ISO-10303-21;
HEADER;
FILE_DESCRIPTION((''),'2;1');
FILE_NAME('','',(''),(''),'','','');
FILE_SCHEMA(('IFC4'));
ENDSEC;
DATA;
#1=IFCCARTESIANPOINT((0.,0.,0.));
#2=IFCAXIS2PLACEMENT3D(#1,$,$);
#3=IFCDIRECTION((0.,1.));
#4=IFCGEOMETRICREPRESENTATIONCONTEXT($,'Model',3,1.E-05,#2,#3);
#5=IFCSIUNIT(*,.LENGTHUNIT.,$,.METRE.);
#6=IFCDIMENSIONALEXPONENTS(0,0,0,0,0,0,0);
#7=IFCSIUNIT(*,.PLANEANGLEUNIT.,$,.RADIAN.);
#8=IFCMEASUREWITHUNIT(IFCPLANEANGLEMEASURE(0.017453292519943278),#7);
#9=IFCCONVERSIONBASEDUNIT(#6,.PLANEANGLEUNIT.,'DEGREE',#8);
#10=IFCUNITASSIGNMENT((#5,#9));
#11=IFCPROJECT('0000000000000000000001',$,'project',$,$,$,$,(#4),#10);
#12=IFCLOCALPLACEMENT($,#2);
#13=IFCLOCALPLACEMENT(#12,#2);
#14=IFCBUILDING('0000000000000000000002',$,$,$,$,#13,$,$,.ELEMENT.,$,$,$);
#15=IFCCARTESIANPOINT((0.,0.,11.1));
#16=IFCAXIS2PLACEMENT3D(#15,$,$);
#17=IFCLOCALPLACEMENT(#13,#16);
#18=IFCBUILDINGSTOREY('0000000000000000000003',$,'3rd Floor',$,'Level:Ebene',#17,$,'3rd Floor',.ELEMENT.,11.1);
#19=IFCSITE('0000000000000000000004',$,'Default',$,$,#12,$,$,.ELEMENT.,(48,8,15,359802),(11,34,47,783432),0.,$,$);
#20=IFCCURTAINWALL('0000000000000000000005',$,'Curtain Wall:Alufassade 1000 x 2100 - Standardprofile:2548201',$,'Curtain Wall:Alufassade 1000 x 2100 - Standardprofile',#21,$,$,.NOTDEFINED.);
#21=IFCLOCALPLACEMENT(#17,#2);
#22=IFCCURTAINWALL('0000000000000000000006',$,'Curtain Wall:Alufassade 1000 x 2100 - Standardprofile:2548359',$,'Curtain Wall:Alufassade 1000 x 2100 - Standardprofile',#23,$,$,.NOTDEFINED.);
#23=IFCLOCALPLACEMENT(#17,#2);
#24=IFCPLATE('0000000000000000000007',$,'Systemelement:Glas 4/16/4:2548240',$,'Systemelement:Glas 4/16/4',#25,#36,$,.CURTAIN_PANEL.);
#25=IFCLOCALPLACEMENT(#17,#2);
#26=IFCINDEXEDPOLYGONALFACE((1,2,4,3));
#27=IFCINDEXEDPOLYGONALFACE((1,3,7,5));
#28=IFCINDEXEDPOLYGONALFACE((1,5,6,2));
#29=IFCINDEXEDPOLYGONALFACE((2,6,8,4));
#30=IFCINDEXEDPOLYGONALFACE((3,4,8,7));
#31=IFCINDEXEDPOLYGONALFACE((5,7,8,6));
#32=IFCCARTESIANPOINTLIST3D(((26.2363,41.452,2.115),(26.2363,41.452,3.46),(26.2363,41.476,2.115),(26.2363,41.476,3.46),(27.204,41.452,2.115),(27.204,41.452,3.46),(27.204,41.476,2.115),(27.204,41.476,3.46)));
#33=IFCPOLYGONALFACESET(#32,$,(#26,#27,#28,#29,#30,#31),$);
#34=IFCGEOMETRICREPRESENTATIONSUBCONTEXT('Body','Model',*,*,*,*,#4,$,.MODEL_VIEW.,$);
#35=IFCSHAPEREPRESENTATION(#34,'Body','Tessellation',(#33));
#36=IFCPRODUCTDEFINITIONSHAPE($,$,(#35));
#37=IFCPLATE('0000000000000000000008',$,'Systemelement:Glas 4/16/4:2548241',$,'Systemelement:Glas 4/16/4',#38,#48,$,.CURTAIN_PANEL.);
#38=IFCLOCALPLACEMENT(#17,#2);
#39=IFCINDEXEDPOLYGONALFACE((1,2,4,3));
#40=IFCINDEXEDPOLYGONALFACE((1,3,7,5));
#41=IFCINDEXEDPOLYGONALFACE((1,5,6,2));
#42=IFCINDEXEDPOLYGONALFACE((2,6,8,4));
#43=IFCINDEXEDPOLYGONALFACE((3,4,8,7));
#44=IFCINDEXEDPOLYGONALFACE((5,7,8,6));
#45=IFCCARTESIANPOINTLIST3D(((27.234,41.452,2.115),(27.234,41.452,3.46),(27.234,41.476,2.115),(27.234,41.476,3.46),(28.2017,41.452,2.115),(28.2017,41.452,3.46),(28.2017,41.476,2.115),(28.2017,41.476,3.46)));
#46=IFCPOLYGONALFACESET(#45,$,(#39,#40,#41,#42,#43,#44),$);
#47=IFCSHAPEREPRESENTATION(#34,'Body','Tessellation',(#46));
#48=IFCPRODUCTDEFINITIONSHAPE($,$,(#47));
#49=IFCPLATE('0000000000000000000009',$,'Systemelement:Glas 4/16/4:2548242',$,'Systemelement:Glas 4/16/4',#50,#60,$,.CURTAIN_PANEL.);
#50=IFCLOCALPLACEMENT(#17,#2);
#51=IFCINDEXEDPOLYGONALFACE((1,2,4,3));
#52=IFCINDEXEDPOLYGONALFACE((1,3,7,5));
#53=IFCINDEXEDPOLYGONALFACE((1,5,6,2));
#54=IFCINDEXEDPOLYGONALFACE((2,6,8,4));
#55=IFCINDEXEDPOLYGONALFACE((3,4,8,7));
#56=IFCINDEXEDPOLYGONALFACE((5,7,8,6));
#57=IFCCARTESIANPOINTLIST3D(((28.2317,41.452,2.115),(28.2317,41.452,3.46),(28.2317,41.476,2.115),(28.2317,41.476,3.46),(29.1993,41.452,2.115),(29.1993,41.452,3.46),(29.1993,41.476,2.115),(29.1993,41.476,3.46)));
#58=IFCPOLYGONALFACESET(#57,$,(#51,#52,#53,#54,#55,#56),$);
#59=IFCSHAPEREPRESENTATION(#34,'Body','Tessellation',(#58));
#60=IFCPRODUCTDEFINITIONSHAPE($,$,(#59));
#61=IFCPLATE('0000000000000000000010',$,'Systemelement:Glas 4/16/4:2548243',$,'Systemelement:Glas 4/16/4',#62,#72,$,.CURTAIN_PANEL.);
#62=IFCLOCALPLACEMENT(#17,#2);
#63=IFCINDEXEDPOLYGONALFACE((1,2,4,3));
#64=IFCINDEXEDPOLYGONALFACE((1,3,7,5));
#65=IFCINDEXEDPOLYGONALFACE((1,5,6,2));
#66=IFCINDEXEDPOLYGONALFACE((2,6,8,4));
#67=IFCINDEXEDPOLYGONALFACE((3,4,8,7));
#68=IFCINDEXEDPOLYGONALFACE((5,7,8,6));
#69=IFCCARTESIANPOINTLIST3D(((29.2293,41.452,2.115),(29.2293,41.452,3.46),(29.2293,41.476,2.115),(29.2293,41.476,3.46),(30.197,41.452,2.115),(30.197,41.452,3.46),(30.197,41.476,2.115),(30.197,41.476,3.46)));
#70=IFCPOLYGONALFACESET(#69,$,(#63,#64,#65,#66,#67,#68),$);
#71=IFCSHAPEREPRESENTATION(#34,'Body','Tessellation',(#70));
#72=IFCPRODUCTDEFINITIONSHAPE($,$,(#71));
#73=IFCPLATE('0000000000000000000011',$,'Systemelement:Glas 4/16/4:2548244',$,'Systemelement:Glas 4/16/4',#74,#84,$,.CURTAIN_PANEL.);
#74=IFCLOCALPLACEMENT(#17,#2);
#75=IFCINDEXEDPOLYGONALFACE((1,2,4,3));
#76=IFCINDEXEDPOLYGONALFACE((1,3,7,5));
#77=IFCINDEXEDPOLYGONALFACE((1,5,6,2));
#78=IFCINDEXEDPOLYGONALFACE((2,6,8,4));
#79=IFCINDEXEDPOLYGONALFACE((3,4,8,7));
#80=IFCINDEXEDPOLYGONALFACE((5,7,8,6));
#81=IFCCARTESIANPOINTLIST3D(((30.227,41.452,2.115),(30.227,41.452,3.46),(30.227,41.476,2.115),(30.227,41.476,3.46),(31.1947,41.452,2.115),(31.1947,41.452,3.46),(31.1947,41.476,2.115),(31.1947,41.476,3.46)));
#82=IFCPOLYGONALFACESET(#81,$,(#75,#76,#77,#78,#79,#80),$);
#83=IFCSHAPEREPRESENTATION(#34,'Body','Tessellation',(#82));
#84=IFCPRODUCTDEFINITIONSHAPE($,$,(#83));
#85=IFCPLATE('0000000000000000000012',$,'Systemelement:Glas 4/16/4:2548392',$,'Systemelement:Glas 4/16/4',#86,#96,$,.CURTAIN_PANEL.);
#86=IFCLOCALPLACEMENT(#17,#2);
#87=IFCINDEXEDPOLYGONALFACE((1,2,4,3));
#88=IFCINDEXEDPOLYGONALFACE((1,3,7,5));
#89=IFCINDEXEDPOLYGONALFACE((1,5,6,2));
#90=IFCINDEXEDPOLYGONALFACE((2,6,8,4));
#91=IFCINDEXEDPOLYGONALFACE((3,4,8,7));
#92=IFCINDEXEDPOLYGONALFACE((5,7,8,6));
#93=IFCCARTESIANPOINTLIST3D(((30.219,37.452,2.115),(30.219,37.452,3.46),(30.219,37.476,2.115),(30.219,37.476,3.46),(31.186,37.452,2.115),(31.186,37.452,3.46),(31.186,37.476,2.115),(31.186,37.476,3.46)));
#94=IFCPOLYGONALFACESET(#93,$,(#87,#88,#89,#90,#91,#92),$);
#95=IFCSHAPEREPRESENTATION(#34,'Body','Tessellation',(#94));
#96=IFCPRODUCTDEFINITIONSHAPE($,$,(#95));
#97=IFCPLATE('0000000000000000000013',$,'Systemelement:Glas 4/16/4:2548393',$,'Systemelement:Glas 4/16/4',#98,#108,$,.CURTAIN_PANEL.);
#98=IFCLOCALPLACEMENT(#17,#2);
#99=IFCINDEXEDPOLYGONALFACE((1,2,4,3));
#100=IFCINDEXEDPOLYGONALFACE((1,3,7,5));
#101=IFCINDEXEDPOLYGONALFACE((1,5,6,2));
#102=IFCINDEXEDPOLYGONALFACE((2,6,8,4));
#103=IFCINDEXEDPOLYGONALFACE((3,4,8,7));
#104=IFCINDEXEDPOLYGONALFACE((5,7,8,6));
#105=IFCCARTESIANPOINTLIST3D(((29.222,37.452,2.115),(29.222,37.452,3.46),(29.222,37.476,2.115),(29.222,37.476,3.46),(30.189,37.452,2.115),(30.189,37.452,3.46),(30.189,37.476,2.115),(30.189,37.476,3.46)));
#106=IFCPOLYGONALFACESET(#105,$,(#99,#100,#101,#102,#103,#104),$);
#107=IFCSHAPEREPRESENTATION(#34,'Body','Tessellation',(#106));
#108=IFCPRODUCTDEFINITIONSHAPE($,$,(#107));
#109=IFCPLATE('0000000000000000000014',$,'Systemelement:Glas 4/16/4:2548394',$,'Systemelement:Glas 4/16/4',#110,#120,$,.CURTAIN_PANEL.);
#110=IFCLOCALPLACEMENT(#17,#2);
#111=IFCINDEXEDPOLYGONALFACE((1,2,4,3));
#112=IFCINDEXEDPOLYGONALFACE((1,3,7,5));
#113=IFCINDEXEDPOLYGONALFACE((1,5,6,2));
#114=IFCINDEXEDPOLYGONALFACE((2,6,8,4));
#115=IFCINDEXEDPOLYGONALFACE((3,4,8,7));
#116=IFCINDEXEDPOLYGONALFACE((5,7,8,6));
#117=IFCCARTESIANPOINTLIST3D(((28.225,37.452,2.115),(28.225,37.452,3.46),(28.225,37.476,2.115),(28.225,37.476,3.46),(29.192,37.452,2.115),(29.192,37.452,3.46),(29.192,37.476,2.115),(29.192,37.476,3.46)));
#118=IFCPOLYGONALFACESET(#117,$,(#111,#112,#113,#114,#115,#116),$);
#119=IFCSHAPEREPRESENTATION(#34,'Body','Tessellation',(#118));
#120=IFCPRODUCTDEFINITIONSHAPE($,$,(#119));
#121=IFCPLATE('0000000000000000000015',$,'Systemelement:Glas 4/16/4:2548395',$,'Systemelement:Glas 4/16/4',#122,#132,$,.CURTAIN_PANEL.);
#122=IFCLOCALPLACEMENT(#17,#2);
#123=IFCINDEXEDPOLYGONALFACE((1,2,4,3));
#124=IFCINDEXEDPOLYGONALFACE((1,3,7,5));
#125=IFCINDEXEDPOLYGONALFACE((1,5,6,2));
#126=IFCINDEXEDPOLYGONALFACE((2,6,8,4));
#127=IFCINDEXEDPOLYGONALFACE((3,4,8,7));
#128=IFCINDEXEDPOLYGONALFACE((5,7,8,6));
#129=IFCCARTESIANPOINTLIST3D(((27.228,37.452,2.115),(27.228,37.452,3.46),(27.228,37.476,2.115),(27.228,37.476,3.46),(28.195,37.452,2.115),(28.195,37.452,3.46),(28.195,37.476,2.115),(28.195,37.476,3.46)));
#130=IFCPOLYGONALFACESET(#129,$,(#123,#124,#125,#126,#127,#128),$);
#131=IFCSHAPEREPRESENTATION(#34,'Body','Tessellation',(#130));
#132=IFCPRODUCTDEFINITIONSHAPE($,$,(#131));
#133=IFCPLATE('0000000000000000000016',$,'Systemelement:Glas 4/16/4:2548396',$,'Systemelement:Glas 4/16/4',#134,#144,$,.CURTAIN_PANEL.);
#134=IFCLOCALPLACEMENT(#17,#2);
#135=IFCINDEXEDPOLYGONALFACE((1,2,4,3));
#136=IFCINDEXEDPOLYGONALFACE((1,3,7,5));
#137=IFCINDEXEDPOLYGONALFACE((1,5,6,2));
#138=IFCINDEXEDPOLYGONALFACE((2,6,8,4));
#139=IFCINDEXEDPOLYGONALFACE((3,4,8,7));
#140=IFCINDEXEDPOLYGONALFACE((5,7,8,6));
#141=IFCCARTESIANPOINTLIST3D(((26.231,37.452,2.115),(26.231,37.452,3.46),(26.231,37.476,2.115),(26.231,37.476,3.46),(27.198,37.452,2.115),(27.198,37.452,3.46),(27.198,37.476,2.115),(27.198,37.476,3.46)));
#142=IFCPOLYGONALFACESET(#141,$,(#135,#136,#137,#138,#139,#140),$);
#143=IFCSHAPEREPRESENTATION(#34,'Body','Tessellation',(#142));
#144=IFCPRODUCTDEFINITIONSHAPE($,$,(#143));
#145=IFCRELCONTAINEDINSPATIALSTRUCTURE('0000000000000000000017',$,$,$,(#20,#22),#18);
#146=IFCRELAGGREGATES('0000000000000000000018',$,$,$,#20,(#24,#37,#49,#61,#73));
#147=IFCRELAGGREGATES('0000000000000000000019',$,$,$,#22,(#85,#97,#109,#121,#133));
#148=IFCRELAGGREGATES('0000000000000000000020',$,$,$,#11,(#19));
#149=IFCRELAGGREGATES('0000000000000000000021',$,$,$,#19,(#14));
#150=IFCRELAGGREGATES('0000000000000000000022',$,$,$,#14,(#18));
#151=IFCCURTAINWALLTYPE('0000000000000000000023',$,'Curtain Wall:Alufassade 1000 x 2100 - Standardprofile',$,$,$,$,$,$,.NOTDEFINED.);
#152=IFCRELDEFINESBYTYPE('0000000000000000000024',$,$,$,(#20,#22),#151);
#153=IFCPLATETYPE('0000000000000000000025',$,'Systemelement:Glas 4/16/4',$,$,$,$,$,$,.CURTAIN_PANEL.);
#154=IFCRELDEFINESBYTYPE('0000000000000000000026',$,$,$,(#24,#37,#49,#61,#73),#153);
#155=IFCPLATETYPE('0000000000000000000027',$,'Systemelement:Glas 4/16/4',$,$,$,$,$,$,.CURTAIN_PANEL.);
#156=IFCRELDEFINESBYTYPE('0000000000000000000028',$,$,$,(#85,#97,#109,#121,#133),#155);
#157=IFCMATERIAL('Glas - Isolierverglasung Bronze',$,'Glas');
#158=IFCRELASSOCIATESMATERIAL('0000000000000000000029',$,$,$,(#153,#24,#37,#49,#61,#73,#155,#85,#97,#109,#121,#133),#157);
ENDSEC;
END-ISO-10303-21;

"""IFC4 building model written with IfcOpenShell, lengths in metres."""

from ifc_helpers import new_model, entity, si_unit, converted_unit, direction, frame, origin, place, context, subcontext, project, spatial, indexed_curve, outline, extrude, source, transform, mapped, material, type_object, type_shapes, element, aggregate, save


model = new_model("IFC4")

# Units and contexts
model_context = context("Model", 3, precision=1e-05, world=origin(), true_north=direction((0.0, 1.0)))
body_context = subcontext(model_context, "Body", "Model", "MODEL_VIEW")
ifc_project = project(units=[si_unit("LENGTHUNIT", "METRE"), converted_unit("PLANEANGLEUNIT", "DEGREE", entity("IfcPlaneAngleMeasure", 0.017453292519943278), si_unit("PLANEANGLEUNIT", "RADIAN"), dimensions=[0, 0, 0, 0, 0, 0, 0])], contexts=[model_context])

# Site, building, storey
site_placement = place(None, origin())
site = spatial("IfcSite", under=ifc_project, at=site_placement, Name="Default", CompositionType="ELEMENT", RefLatitude=(48, 8, 15, 359802), RefLongitude=(11, 34, 47, 783432), RefElevation=0.0)
building_placement = place(site_placement, origin())
building = spatial("IfcBuilding", under=site, at=building_placement, CompositionType="ELEMENT")
storey_placement = place(building_placement, frame((0.0, 0.0, 11.1)))
storey = spatial("IfcBuildingStorey", under=building, at=storey_placement, Name="3rd Floor", ObjectType="Level:Ebene", LongName="3rd Floor", CompositionType="ELEMENT", Elevation=11.1)

# Curtain walls
curtain_wall_type = type_object("IfcCurtainWallType", Name="Curtain Wall:Alufassade 1000 x 2100 - Standardprofile", PredefinedType="NOTDEFINED")
curtain_wall_1_placement = place(storey_placement, frame((0.0, 0.0, -11.1)))
curtain_wall_1 = element("IfcCurtainWall", 1, at=curtain_wall_1_placement, inside=storey, type_object=curtain_wall_type, Name="Curtain Wall:Alufassade 1000 x 2100 - Standardprofile:2548201", ObjectType="Curtain Wall:Alufassade 1000 x 2100 - Standardprofile", PredefinedType="NOTDEFINED")
curtain_wall_2_placement = place(storey_placement, frame((0.0, 0.0, -11.1)))
curtain_wall_2 = element("IfcCurtainWall", 2, at=curtain_wall_2_placement, inside=storey, type_object=curtain_wall_type, Name="Curtain Wall:Alufassade 1000 x 2100 - Standardprofile:2548359", ObjectType="Curtain Wall:Alufassade 1000 x 2100 - Standardprofile", PredefinedType="NOTDEFINED")

# Plates
ifc_material_1 = material(Name="Glas - Isolierverglasung Bronze", Category="Glas")
plate_type_1 = type_object("IfcPlateType", Name="Systemelement:Glas 4/16/4", PredefinedType="CURTAIN_PANEL", material=ifc_material_1)
shared_shape_1 = source(origin(), body_context, "Body", "SweptSolid", [
    extrude(outline(indexed_curve([(-0.012, -0.4838), (0.012, -0.4838), (0.012, 0.4838), (-0.012, 0.4838), (-0.012, -0.4838)], self_intersect=False)), frame((0.0, 0.0, 0.0), z_axis=(0.0, 0.0, 1.0), x_axis=(0.0, 1.0, 0.0)), (0.0, 0.0, 1.0), 1.345),
])
type_shapes(plate_type_1, [shared_shape_1])
plate_1_placement = place(curtain_wall_1_placement, frame((26.7202, 41.464, 13.215)))
plate_1 = element("IfcPlate", 3, at=plate_1_placement, type_object=plate_type_1, material=ifc_material_1, Name="Systemelement:Glas 4/16/4:2548240", ObjectType="Systemelement:Glas 4/16/4", PredefinedType="CURTAIN_PANEL", context=body_context, shape_type="MappedRepresentation", body=[
    mapped(shared_shape_1, transform((0.0, 0.0, 0.0), scale=1.0)),
])
plate_2_placement = place(curtain_wall_1_placement, frame((27.7178, 41.464, 13.215)))
plate_2 = element("IfcPlate", 4, at=plate_2_placement, type_object=plate_type_1, material=ifc_material_1, Name="Systemelement:Glas 4/16/4:2548241", ObjectType="Systemelement:Glas 4/16/4", PredefinedType="CURTAIN_PANEL", context=body_context, shape_type="MappedRepresentation", body=[
    mapped(shared_shape_1, transform((0.0, 0.0, 0.0), scale=1.0)),
])
plate_3_placement = place(curtain_wall_1_placement, frame((28.7155, 41.464, 13.215)))
plate_3 = element("IfcPlate", 5, at=plate_3_placement, type_object=plate_type_1, material=ifc_material_1, Name="Systemelement:Glas 4/16/4:2548242", ObjectType="Systemelement:Glas 4/16/4", PredefinedType="CURTAIN_PANEL", context=body_context, shape_type="MappedRepresentation", body=[
    mapped(shared_shape_1, transform((0.0, 0.0, 0.0), scale=1.0)),
])
plate_4_placement = place(curtain_wall_1_placement, frame((29.7132, 41.464, 13.215)))
plate_4 = element("IfcPlate", 6, at=plate_4_placement, type_object=plate_type_1, material=ifc_material_1, Name="Systemelement:Glas 4/16/4:2548243", ObjectType="Systemelement:Glas 4/16/4", PredefinedType="CURTAIN_PANEL", context=body_context, shape_type="MappedRepresentation", body=[
    mapped(shared_shape_1, transform((0.0, 0.0, 0.0), scale=1.0)),
])
plate_5_placement = place(curtain_wall_1_placement, frame((30.7108, 41.464, 13.215)))
plate_5 = element("IfcPlate", 7, at=plate_5_placement, type_object=plate_type_1, material=ifc_material_1, Name="Systemelement:Glas 4/16/4:2548244", ObjectType="Systemelement:Glas 4/16/4", PredefinedType="CURTAIN_PANEL", context=body_context, shape_type="MappedRepresentation", body=[
    mapped(shared_shape_1, transform((0.0, 0.0, 0.0), scale=1.0)),
])
aggregate(curtain_wall_1, [plate_1, plate_2, plate_3, plate_4, plate_5])
plate_type_2 = type_object("IfcPlateType", Name="Systemelement:Glas 4/16/4", PredefinedType="CURTAIN_PANEL", material=ifc_material_1)
shared_shape_2 = source(origin(), body_context, "Body", "SweptSolid", [
    extrude(outline(indexed_curve([(-0.012, -0.4835), (0.012, -0.4835), (0.012, 0.4835), (-0.012, 0.4835), (-0.012, -0.4835)], self_intersect=False)), frame((0.0, 0.0, 0.0), z_axis=(0.0, 0.0, 1.0), x_axis=(0.0, 1.0, 0.0)), (0.0, 0.0, 1.0), 1.345),
])
type_shapes(plate_type_2, [shared_shape_2])
plate_6_placement = place(curtain_wall_2_placement, frame((30.7025, 37.464, 13.215), z_axis=(0.0, 0.0, 1.0), x_axis=(-1.0, 0.0, 0.0)))
plate_6 = element("IfcPlate", 8, at=plate_6_placement, type_object=plate_type_2, material=ifc_material_1, Name="Systemelement:Glas 4/16/4:2548392", ObjectType="Systemelement:Glas 4/16/4", PredefinedType="CURTAIN_PANEL", context=body_context, shape_type="MappedRepresentation", body=[
    mapped(shared_shape_2, transform((0.0, 0.0, 0.0), scale=1.0)),
])
plate_7_placement = place(curtain_wall_2_placement, frame((29.7055, 37.464, 13.215), z_axis=(0.0, 0.0, 1.0), x_axis=(-1.0, 0.0, 0.0)))
plate_7 = element("IfcPlate", 9, at=plate_7_placement, type_object=plate_type_2, material=ifc_material_1, Name="Systemelement:Glas 4/16/4:2548393", ObjectType="Systemelement:Glas 4/16/4", PredefinedType="CURTAIN_PANEL", context=body_context, shape_type="MappedRepresentation", body=[
    mapped(shared_shape_2, transform((0.0, 0.0, 0.0), scale=1.0)),
])
plate_8_placement = place(curtain_wall_2_placement, frame((28.7085, 37.464, 13.215), z_axis=(0.0, 0.0, 1.0), x_axis=(-1.0, 0.0, 0.0)))
plate_8 = element("IfcPlate", 10, at=plate_8_placement, type_object=plate_type_2, material=ifc_material_1, Name="Systemelement:Glas 4/16/4:2548394", ObjectType="Systemelement:Glas 4/16/4", PredefinedType="CURTAIN_PANEL", context=body_context, shape_type="MappedRepresentation", body=[
    mapped(shared_shape_2, transform((0.0, 0.0, 0.0), scale=1.0)),
])
plate_9_placement = place(curtain_wall_2_placement, frame((27.7115, 37.464, 13.215), z_axis=(0.0, 0.0, 1.0), x_axis=(-1.0, 0.0, 0.0)))
plate_9 = element("IfcPlate", 11, at=plate_9_placement, type_object=plate_type_2, material=ifc_material_1, Name="Systemelement:Glas 4/16/4:2548395", ObjectType="Systemelement:Glas 4/16/4", PredefinedType="CURTAIN_PANEL", context=body_context, shape_type="MappedRepresentation", body=[
    mapped(shared_shape_2, transform((0.0, 0.0, 0.0), scale=1.0)),
])
plate_10_placement = place(curtain_wall_2_placement, frame((26.7145, 37.464, 13.215), z_axis=(0.0, 0.0, 1.0), x_axis=(-1.0, 0.0, 0.0)))
plate_10 = element("IfcPlate", 12, at=plate_10_placement, type_object=plate_type_2, material=ifc_material_1, Name="Systemelement:Glas 4/16/4:2548396", ObjectType="Systemelement:Glas 4/16/4", PredefinedType="CURTAIN_PANEL", context=body_context, shape_type="MappedRepresentation", body=[
    mapped(shared_shape_2, transform((0.0, 0.0, 0.0), scale=1.0)),
])
aggregate(curtain_wall_2, [plate_6, plate_7, plate_8, plate_9, plate_10])

save(model, "model.ifc")
